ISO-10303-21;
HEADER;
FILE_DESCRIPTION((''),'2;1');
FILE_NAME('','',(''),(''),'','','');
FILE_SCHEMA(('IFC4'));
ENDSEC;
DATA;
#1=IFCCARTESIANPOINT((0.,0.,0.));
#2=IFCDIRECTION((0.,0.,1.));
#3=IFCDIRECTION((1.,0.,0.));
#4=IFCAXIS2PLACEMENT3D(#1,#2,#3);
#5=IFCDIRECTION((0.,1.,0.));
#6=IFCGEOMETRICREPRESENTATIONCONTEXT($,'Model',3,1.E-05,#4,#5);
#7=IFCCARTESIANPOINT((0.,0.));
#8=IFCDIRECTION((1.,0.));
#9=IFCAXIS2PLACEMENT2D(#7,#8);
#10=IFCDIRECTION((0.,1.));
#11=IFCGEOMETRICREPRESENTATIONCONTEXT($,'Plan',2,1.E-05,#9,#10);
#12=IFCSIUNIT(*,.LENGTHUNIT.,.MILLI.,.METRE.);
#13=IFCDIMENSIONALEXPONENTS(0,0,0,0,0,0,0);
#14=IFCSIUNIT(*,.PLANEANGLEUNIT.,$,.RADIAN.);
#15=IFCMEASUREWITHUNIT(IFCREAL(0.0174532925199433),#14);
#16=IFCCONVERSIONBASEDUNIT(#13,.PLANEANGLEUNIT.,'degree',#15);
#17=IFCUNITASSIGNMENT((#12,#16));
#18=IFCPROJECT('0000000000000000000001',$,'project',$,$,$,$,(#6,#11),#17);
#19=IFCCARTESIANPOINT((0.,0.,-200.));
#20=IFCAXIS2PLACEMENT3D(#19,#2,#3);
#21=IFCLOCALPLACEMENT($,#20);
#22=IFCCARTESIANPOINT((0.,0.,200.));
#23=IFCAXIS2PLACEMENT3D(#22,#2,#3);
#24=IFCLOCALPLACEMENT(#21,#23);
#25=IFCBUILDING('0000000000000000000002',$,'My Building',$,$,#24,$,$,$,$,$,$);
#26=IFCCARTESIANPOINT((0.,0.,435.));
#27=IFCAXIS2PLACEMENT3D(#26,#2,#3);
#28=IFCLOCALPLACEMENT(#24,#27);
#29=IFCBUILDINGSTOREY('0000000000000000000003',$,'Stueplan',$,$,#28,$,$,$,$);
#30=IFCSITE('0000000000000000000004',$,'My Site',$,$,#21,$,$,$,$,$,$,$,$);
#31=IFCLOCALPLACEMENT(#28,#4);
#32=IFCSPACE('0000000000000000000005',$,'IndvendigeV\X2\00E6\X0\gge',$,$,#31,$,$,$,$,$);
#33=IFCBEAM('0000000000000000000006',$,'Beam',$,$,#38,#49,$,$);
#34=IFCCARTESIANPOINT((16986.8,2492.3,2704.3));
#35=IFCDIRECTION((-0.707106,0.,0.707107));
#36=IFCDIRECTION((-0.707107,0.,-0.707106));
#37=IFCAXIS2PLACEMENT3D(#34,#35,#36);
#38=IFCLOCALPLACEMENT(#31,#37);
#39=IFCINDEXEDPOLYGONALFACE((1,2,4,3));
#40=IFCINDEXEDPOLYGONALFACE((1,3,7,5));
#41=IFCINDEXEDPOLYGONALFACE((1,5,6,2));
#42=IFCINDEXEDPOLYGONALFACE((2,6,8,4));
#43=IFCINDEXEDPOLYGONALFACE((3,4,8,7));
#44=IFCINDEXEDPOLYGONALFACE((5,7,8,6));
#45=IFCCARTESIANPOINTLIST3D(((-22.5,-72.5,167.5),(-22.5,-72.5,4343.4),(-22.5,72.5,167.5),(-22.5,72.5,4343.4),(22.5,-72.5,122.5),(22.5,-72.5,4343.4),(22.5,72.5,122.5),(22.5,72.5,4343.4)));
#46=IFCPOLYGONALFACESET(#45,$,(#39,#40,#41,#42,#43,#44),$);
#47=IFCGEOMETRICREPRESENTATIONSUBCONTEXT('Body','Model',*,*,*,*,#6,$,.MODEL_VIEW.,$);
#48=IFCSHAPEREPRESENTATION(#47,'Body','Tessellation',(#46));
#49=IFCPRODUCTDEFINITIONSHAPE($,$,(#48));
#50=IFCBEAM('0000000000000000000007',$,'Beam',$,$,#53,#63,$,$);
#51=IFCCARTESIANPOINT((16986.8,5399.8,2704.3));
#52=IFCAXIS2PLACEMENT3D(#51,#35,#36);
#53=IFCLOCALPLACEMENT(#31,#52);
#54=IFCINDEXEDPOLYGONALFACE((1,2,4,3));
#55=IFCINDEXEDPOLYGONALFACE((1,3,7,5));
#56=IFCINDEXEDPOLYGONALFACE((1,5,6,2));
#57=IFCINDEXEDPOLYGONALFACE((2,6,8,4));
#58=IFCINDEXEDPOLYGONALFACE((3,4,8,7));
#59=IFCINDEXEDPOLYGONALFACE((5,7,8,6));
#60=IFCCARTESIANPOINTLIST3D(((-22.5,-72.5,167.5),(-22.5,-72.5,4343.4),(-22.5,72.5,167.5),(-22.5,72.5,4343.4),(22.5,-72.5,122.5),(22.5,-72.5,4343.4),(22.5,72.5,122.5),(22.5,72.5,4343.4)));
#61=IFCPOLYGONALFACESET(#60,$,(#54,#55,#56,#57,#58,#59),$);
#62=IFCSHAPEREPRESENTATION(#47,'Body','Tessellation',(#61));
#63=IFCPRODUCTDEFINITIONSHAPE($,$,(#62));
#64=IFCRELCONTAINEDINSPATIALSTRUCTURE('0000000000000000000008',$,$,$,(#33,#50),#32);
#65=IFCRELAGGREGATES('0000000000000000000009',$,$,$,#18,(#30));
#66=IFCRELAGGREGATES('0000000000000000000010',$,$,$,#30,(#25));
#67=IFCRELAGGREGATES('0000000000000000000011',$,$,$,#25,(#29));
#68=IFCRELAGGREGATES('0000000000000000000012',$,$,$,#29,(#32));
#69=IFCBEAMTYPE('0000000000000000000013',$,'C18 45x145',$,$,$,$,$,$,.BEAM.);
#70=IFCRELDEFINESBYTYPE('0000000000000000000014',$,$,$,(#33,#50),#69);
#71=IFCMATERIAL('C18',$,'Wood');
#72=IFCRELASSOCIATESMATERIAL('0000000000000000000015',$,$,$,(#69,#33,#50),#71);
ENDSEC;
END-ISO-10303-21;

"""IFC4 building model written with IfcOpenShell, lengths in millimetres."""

from ifc_helpers import new_model, entity, si_unit, converted_unit, direction, frame, origin_with_axes, origin_2d_with_axis, place, context, subcontext, project, spatial, rectangle, extrude, clip, halfspace, material, material_profile, profile_set, profile_usage, type_object, element, save


model = new_model("IFC4")

# Units and contexts
model_context = context("Model", 3, precision=1e-05, world=origin_with_axes(), true_north=direction((0.0, 1.0, 0.0)))
plan_context = context("Plan", 2, precision=1e-05, world=origin_2d_with_axis(), true_north=direction((0.0, 1.0)))
body_context_1 = subcontext(model_context, "Body", "Model", "MODEL_VIEW")
ifc_project = project(units=[si_unit("LENGTHUNIT", "METRE", prefix="MILLI"), converted_unit("PLANEANGLEUNIT", "degree", entity("IfcReal", 0.0174532925199433), si_unit("PLANEANGLEUNIT", "RADIAN"), dimensions=[0, 0, 0, 0, 0, 0, 0])], contexts=[model_context, plan_context])

# Site, building, storey
site_placement = place(None, frame((0.0, 0.0, -200.0), z_axis=(0.0, 0.0, 1.0), x_axis=(1.0, 0.0, 0.0)))
site = spatial("IfcSite", under=ifc_project, at=site_placement, Name="My Site")
building_placement = place(site_placement, frame((0.0, 0.0, 200.0), z_axis=(0.0, 0.0, 1.0), x_axis=(1.0, 0.0, 0.0)))
building = spatial("IfcBuilding", under=site, at=building_placement, Name="My Building")
storey_placement = place(building_placement, frame((0.0, 0.0, 435.0), z_axis=(0.0, 0.0, 1.0), x_axis=(1.0, 0.0, 0.0)))
storey = spatial("IfcBuildingStorey", under=building, at=storey_placement, Name="Stueplan")

# Shared definitions
ifc_material = material(Name="C18", Category="Wood")

# Shared definitions
space_1_placement = place(storey_placement, frame((0.0, 0.0, 0.0), z_axis=(0.0, 0.0, 1.0), x_axis=(1.0, 0.0, 0.0)))
space_1 = spatial("IfcSpace", under=storey, at=space_1_placement, Name="IndvendigeVægge")

# Beams
ifc_material_profile_1 = material_profile(ifc_material, rectangle(XDim=45.0, YDim=145.0))
ifc_profile_set_1 = profile_set([ifc_material_profile_1], Name="woodStructural")
beam_type_1 = type_object("IfcBeamType", Name="C18 45x145", PredefinedType="BEAM", material=ifc_profile_set_1)
ifc_profile_usage_1 = profile_usage(ifc_profile_set_1)
beam_1_placement = place(space_1_placement, frame((16986.8, 2492.3, 2704.3), z_axis=(-0.707106, 0.0, 0.707107), x_axis=(-0.707107, 0.0, -0.707106)))
element("IfcBeam", 1, at=beam_1_placement, inside=space_1, type_object=beam_type_1, material=ifc_profile_usage_1, Name="Beam", context=body_context_1, shape_type="Clipping", body=[
    clip(extrude(rectangle(XDim=45.0, YDim=145.0), origin_with_axes(), (0.0, 0.0, 1.0), 4343.4), halfspace(frame((1952.9, 0.0, -1807.9), z_axis=(-0.707107, 0.0, -0.707107), x_axis=(0.0, 1.0, 0.0)), False)),
])
ifc_profile_usage_2 = profile_usage(ifc_profile_set_1)
beam_2_placement = place(space_1_placement, frame((16986.8, 5399.8, 2704.3), z_axis=(-0.707106, 0.0, 0.707107), x_axis=(-0.707107, 0.0, -0.707106)))
element("IfcBeam", 2, at=beam_2_placement, inside=space_1, type_object=beam_type_1, material=ifc_profile_usage_2, Name="Beam", context=body_context_1, shape_type="Clipping", body=[
    clip(extrude(rectangle(XDim=45.0, YDim=145.0), origin_with_axes(), (0.0, 0.0, 1.0), 4343.4), halfspace(frame((1952.9, 0.0, -1807.9), z_axis=(-0.707107, 0.0, -0.707107), x_axis=(0.0, 1.0, 0.0)), False)),
])

save(model, "model.ifc")
